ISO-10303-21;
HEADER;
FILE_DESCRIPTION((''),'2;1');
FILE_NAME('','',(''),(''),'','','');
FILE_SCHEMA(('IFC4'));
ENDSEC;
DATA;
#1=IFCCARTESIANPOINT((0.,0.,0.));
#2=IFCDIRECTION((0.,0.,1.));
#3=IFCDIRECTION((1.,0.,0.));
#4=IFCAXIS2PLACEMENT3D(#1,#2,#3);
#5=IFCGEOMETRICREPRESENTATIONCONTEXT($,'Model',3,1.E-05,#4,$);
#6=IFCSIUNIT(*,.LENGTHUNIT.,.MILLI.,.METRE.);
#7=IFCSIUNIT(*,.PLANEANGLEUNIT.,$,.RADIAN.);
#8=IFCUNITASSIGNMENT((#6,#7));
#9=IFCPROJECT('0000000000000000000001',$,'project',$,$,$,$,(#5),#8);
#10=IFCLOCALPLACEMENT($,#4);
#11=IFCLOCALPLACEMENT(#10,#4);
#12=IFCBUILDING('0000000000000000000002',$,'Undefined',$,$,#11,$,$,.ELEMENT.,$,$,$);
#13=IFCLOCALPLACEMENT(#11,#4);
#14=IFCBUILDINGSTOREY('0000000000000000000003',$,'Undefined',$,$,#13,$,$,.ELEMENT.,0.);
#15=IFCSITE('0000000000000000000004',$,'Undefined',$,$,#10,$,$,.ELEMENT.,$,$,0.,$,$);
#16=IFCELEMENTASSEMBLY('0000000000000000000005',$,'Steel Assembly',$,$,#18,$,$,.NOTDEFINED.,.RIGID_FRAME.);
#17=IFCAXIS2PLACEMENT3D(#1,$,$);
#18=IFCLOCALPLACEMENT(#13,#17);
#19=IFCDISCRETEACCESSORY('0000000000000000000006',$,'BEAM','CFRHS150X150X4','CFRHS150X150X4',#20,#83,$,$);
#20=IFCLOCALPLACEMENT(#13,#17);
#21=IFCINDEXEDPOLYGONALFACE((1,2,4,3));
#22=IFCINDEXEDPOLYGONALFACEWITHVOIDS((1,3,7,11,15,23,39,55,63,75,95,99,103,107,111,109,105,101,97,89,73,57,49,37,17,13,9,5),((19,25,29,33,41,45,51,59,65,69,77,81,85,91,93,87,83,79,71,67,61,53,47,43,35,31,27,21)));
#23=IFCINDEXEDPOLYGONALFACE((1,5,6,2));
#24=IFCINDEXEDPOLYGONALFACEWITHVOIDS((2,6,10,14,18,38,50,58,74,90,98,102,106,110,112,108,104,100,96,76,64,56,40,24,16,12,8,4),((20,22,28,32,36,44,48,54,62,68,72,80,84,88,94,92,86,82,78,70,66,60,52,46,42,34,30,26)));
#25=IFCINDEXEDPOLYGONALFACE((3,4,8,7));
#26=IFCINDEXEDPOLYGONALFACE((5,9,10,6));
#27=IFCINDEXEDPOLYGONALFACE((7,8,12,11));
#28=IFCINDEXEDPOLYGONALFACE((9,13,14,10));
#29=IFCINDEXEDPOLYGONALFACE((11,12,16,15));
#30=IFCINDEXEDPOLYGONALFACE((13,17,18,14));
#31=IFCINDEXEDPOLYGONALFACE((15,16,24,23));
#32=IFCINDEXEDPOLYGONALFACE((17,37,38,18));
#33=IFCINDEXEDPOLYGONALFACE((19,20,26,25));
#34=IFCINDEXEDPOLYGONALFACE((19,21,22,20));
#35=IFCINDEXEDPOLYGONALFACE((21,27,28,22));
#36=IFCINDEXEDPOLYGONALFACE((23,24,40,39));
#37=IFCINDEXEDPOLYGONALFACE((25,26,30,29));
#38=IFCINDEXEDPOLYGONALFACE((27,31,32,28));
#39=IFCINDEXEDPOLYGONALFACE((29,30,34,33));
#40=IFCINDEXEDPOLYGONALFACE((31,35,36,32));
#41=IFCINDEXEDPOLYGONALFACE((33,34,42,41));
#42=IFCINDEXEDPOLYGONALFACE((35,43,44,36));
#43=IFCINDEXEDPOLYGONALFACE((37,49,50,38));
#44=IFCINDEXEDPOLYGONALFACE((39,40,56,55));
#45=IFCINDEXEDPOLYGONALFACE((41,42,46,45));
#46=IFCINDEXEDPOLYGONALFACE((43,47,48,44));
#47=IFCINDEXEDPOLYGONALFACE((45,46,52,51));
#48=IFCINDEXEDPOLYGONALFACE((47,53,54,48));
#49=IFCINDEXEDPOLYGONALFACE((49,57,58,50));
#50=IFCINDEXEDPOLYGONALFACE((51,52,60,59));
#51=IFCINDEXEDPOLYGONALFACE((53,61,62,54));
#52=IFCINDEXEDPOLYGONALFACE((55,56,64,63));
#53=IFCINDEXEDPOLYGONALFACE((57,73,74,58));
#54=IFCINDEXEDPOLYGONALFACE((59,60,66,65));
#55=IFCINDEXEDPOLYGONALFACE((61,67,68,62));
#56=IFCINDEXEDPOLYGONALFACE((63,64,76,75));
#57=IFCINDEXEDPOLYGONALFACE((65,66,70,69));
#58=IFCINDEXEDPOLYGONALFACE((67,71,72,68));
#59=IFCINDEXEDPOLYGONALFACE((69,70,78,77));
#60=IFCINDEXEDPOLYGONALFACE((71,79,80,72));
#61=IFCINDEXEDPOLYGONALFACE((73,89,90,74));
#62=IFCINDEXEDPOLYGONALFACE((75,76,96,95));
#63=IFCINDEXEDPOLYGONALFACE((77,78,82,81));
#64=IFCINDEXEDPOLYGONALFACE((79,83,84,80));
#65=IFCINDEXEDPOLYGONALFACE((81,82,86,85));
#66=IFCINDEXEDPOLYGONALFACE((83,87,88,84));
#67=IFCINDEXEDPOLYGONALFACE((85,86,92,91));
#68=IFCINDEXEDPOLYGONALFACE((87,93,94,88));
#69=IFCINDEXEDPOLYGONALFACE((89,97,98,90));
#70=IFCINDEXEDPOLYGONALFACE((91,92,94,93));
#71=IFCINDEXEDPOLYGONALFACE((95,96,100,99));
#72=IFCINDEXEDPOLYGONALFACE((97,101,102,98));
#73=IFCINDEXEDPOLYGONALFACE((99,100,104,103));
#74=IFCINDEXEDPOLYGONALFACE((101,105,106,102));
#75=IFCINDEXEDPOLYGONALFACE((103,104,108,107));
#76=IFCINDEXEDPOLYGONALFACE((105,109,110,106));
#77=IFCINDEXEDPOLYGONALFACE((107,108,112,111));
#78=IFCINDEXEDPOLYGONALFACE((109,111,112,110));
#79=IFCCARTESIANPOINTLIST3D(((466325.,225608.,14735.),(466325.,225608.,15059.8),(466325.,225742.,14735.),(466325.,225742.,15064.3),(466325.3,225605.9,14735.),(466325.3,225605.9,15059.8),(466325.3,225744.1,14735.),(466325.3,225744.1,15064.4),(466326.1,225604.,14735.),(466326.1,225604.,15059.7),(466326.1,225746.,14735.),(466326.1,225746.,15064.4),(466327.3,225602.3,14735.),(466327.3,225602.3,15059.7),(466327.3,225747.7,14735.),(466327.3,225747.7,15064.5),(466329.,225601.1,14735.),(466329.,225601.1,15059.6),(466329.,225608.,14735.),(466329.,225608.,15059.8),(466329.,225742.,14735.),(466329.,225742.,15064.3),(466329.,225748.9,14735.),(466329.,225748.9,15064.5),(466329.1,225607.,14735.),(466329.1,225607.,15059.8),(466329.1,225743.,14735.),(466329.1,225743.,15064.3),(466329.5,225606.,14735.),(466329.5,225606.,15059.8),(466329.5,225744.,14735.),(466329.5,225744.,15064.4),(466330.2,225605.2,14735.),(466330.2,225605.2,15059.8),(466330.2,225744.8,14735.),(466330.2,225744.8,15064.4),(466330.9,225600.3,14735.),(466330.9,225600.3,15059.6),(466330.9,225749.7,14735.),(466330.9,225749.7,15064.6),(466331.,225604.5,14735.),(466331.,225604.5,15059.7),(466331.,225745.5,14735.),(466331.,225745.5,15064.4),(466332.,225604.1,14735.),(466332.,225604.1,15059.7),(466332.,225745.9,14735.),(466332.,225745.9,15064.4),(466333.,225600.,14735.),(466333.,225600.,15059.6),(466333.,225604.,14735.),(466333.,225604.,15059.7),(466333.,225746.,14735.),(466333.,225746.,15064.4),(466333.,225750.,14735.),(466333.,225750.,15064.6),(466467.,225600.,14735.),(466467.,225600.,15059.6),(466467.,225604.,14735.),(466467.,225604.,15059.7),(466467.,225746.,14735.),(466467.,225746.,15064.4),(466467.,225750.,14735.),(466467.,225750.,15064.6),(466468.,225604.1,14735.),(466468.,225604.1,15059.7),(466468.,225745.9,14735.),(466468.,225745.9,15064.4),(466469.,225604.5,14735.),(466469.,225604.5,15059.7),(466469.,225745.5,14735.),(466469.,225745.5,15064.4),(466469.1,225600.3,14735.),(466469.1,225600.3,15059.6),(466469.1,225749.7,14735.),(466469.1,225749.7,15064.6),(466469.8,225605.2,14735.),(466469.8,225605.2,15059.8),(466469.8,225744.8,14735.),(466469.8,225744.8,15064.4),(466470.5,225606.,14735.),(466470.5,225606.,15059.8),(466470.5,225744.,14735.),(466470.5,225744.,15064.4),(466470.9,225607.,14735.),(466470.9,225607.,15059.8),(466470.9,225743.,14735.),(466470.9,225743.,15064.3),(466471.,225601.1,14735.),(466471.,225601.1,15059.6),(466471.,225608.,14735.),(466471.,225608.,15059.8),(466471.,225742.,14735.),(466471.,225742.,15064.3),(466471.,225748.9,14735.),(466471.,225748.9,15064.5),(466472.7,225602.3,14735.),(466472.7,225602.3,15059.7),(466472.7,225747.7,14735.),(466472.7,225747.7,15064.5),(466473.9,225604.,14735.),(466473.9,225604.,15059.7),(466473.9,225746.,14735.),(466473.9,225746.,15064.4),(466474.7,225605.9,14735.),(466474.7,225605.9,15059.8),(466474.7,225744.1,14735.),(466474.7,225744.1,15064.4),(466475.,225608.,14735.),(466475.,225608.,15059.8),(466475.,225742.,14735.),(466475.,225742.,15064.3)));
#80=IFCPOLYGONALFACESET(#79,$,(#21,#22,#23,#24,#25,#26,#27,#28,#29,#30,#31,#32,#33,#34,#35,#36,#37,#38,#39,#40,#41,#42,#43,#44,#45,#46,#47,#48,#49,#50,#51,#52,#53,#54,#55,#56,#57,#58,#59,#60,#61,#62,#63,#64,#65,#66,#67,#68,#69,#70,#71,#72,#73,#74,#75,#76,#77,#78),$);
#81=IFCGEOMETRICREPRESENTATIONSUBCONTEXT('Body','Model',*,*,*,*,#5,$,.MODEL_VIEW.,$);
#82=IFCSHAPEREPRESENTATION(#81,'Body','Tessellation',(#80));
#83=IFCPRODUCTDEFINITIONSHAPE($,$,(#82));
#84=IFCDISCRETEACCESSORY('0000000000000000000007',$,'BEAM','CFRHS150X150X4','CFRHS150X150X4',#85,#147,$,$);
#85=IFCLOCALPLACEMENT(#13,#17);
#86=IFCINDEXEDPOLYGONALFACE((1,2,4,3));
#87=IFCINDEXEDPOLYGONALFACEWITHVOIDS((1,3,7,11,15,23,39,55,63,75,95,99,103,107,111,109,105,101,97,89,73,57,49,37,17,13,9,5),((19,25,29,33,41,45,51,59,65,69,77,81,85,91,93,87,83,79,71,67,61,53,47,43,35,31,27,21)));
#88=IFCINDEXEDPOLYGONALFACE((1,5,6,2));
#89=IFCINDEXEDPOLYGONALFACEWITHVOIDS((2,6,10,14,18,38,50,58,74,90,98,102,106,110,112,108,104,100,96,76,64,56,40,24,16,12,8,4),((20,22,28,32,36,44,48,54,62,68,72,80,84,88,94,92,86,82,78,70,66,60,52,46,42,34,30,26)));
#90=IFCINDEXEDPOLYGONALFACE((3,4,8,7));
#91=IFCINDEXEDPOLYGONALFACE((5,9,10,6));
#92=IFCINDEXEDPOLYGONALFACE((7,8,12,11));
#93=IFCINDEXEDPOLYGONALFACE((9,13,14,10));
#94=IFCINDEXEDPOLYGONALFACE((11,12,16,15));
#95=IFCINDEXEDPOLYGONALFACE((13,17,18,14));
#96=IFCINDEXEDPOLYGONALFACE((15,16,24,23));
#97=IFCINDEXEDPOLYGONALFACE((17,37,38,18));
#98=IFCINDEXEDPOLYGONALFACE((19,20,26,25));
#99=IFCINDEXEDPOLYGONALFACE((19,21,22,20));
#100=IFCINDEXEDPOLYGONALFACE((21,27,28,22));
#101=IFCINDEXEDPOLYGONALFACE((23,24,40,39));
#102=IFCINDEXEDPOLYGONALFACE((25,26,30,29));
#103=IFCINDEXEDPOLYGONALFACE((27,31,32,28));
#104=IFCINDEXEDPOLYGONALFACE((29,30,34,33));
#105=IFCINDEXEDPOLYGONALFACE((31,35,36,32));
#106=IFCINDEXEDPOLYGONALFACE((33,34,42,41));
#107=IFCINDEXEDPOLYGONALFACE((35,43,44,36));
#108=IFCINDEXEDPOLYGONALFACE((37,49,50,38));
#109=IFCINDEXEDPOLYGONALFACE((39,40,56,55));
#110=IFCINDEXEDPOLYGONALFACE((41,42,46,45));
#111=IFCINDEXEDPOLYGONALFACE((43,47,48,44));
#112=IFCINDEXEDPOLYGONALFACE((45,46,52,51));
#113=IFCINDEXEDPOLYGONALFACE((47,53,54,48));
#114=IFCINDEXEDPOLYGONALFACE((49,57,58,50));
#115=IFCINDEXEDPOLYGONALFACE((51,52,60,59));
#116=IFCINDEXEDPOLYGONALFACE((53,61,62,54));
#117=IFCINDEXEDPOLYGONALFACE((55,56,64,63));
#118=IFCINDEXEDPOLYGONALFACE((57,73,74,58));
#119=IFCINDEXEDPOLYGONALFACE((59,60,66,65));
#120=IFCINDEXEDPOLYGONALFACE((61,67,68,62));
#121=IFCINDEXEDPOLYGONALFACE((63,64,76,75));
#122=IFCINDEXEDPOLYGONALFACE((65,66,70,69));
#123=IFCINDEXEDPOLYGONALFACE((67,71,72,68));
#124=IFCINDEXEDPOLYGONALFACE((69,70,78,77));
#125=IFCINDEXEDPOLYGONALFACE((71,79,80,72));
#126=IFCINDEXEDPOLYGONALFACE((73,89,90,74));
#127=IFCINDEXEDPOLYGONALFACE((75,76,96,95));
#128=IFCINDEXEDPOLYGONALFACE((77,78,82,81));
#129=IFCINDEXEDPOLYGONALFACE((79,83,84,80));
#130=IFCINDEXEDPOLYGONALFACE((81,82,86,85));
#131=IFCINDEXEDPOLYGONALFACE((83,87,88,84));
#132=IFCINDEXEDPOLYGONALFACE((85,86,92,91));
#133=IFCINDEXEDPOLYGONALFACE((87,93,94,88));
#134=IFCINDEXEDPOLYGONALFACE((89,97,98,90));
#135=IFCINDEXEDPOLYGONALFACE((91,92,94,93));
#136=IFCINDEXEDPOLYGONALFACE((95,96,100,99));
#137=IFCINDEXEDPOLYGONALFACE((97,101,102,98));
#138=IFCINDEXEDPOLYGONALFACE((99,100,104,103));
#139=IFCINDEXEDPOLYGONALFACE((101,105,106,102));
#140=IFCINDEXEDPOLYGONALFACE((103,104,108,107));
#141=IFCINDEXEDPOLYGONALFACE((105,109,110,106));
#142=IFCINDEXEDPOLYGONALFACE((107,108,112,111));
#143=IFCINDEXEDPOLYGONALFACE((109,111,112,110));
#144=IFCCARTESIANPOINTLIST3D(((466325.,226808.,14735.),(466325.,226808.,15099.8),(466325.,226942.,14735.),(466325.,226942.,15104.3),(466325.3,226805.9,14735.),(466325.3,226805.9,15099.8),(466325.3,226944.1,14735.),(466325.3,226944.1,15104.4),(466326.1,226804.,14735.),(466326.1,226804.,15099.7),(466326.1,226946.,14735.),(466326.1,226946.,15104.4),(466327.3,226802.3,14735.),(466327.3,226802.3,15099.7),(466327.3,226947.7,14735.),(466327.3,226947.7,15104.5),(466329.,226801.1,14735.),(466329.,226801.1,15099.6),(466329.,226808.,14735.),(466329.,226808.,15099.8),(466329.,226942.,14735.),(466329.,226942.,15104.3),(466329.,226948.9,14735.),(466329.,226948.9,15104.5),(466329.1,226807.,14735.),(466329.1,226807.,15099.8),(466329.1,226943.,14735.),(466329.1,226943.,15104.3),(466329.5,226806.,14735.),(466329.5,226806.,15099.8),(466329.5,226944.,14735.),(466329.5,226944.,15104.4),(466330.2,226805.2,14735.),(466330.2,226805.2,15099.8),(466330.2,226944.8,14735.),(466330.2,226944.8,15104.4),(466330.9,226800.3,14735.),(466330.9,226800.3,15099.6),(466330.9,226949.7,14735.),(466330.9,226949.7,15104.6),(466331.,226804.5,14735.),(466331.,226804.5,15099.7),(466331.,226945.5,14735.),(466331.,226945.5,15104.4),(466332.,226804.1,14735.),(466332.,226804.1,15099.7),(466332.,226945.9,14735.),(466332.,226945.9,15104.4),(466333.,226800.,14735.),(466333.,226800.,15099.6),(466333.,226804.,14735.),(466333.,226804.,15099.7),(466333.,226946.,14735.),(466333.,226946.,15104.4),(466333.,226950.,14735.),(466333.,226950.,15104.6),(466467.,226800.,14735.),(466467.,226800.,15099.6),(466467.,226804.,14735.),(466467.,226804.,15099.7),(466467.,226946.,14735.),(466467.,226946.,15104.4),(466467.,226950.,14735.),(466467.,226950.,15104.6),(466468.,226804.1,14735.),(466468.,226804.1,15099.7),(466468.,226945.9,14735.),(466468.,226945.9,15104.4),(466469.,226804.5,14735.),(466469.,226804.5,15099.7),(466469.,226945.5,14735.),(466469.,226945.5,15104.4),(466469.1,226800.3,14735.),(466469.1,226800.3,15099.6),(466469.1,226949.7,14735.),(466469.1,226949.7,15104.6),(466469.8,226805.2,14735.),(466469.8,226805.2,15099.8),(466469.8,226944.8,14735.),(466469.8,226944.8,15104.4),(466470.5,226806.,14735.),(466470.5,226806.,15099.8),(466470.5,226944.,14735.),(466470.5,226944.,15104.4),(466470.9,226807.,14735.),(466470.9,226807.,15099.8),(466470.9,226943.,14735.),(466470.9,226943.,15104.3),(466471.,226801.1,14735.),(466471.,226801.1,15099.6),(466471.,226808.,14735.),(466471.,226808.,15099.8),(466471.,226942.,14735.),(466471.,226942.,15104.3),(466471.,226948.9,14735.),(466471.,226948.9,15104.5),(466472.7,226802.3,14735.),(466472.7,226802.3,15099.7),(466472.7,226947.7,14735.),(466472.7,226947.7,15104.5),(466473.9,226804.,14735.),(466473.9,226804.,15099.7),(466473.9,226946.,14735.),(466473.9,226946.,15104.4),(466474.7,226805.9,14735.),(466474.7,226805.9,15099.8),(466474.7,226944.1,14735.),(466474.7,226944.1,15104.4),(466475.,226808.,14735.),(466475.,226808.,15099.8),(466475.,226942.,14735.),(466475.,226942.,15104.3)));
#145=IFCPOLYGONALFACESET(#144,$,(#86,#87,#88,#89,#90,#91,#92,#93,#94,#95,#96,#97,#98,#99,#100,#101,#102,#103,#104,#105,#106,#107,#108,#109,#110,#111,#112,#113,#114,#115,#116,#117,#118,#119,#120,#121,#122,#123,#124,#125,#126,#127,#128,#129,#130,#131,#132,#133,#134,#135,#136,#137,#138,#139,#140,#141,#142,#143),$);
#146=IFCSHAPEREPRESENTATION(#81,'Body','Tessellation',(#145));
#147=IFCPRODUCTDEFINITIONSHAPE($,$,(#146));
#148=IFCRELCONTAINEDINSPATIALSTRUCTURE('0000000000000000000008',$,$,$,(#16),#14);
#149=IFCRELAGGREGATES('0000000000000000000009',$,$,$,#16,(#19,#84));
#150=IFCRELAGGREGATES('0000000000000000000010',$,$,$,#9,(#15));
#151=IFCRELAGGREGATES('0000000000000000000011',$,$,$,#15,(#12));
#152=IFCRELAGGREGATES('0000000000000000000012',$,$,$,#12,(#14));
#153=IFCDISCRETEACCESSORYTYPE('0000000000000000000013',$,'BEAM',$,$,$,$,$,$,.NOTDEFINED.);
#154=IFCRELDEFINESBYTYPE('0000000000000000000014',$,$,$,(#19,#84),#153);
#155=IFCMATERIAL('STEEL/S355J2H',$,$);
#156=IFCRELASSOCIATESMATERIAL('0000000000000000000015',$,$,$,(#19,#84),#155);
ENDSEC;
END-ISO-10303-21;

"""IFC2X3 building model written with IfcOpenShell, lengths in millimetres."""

from ifc_helpers import new_model, si_unit, frame, origin_with_axes, origin_2d_with_axis, place, context, subcontext, project, spatial, hollow_rectangle, extrude, clip, halfspace, material, type_object, element, aggregate, save


model = new_model("IFC2X3")

# Units and contexts
model_context = context("Model", 3, precision=1e-05, world=origin_with_axes())
body_context = subcontext(model_context, "Body", "Model", "MODEL_VIEW")
ifc_project = project(units=[si_unit("LENGTHUNIT", "METRE", prefix="MILLI"), si_unit("PLANEANGLEUNIT", "RADIAN")], contexts=[model_context])

# Site, building, storey
site_placement = place(None, origin_with_axes())
site = spatial("IfcSite", under=ifc_project, at=site_placement, Name="Undefined", CompositionType="ELEMENT", RefElevation=0.0)
building_placement = place(site_placement, origin_with_axes())
building = spatial("IfcBuilding", under=site, at=building_placement, Name="Undefined", CompositionType="ELEMENT")
storey_placement = place(building_placement, origin_with_axes())
storey = spatial("IfcBuildingStorey", under=building, at=storey_placement, Name="Undefined", CompositionType="ELEMENT", Elevation=0.0)

# Shared definitions
ifc_material_1 = material(Name="STEEL/S355J2H")

# Element assembly, discrete accessories
assembly_1_placement = place(storey_placement, origin_with_axes())
assembly_1 = element("IfcElementAssembly", 1, at=assembly_1_placement, inside=storey, Name="Steel Assembly", AssemblyPlace="NOTDEFINED", PredefinedType="RIGID_FRAME")
discrete_accessory_type_1 = type_object("IfcDiscreteAccessoryType", Name="BEAM")
discrete_accessory_1_placement = place(assembly_1_placement, frame((466400.0, 225675.0, 14720.0), z_axis=(0.0, 0.0, 1.0), x_axis=(1.0, 0.0, 0.0)))
discrete_accessory_1 = element("IfcDiscreteAccessory", 2, at=discrete_accessory_1_placement, type_object=discrete_accessory_type_1, material=ifc_material_1, Name="BEAM", Description="CFRHS150X150X4", ObjectType="CFRHS150X150X4", context=body_context, shape_type="Clipping", body=[
    clip(extrude(hollow_rectangle(XDim=150.0, YDim=150.0, WallThickness=4.0, InnerFilletRadius=4.0, OuterFilletRadius=8.0, at=origin_2d_with_axis()), frame((0.0, 0.0, 344.6), z_axis=(0.0, 0.0, -1.0), x_axis=(0.0, -1.0, 0.0)), (0.0, 0.0, 1.0), 329.6), halfspace(frame((-1000.0, 2.7, 342.2), z_axis=(0.0, 0.033315, -0.999445), x_axis=(0.0, -0.999445, -0.033315)), True)),
])
discrete_accessory_2_placement = place(assembly_1_placement, frame((466400.0, 226875.0, 14720.0), z_axis=(0.0, 0.0, 1.0), x_axis=(1.0, 0.0, 0.0)))
discrete_accessory_2 = element("IfcDiscreteAccessory", 3, at=discrete_accessory_2_placement, type_object=discrete_accessory_type_1, material=ifc_material_1, Name="BEAM", Description="CFRHS150X150X4", ObjectType="CFRHS150X150X4", context=body_context, shape_type="Clipping", body=[
    clip(extrude(hollow_rectangle(XDim=150.0, YDim=150.0, WallThickness=4.0, InnerFilletRadius=4.0, OuterFilletRadius=8.0, at=origin_2d_with_axis()), frame((0.0, 0.0, 384.6), z_axis=(0.0, 0.0, -1.0), x_axis=(0.0, -1.0, 0.0)), (0.0, 0.0, 1.0), 369.6), halfspace(frame((-1000.0, 2.7, 382.2), z_axis=(0.0, 0.033315, -0.999445), x_axis=(0.0, -0.999445, -0.033315)), True)),
])
aggregate(assembly_1, [discrete_accessory_1, discrete_accessory_2])

save(model, "model.ifc")
